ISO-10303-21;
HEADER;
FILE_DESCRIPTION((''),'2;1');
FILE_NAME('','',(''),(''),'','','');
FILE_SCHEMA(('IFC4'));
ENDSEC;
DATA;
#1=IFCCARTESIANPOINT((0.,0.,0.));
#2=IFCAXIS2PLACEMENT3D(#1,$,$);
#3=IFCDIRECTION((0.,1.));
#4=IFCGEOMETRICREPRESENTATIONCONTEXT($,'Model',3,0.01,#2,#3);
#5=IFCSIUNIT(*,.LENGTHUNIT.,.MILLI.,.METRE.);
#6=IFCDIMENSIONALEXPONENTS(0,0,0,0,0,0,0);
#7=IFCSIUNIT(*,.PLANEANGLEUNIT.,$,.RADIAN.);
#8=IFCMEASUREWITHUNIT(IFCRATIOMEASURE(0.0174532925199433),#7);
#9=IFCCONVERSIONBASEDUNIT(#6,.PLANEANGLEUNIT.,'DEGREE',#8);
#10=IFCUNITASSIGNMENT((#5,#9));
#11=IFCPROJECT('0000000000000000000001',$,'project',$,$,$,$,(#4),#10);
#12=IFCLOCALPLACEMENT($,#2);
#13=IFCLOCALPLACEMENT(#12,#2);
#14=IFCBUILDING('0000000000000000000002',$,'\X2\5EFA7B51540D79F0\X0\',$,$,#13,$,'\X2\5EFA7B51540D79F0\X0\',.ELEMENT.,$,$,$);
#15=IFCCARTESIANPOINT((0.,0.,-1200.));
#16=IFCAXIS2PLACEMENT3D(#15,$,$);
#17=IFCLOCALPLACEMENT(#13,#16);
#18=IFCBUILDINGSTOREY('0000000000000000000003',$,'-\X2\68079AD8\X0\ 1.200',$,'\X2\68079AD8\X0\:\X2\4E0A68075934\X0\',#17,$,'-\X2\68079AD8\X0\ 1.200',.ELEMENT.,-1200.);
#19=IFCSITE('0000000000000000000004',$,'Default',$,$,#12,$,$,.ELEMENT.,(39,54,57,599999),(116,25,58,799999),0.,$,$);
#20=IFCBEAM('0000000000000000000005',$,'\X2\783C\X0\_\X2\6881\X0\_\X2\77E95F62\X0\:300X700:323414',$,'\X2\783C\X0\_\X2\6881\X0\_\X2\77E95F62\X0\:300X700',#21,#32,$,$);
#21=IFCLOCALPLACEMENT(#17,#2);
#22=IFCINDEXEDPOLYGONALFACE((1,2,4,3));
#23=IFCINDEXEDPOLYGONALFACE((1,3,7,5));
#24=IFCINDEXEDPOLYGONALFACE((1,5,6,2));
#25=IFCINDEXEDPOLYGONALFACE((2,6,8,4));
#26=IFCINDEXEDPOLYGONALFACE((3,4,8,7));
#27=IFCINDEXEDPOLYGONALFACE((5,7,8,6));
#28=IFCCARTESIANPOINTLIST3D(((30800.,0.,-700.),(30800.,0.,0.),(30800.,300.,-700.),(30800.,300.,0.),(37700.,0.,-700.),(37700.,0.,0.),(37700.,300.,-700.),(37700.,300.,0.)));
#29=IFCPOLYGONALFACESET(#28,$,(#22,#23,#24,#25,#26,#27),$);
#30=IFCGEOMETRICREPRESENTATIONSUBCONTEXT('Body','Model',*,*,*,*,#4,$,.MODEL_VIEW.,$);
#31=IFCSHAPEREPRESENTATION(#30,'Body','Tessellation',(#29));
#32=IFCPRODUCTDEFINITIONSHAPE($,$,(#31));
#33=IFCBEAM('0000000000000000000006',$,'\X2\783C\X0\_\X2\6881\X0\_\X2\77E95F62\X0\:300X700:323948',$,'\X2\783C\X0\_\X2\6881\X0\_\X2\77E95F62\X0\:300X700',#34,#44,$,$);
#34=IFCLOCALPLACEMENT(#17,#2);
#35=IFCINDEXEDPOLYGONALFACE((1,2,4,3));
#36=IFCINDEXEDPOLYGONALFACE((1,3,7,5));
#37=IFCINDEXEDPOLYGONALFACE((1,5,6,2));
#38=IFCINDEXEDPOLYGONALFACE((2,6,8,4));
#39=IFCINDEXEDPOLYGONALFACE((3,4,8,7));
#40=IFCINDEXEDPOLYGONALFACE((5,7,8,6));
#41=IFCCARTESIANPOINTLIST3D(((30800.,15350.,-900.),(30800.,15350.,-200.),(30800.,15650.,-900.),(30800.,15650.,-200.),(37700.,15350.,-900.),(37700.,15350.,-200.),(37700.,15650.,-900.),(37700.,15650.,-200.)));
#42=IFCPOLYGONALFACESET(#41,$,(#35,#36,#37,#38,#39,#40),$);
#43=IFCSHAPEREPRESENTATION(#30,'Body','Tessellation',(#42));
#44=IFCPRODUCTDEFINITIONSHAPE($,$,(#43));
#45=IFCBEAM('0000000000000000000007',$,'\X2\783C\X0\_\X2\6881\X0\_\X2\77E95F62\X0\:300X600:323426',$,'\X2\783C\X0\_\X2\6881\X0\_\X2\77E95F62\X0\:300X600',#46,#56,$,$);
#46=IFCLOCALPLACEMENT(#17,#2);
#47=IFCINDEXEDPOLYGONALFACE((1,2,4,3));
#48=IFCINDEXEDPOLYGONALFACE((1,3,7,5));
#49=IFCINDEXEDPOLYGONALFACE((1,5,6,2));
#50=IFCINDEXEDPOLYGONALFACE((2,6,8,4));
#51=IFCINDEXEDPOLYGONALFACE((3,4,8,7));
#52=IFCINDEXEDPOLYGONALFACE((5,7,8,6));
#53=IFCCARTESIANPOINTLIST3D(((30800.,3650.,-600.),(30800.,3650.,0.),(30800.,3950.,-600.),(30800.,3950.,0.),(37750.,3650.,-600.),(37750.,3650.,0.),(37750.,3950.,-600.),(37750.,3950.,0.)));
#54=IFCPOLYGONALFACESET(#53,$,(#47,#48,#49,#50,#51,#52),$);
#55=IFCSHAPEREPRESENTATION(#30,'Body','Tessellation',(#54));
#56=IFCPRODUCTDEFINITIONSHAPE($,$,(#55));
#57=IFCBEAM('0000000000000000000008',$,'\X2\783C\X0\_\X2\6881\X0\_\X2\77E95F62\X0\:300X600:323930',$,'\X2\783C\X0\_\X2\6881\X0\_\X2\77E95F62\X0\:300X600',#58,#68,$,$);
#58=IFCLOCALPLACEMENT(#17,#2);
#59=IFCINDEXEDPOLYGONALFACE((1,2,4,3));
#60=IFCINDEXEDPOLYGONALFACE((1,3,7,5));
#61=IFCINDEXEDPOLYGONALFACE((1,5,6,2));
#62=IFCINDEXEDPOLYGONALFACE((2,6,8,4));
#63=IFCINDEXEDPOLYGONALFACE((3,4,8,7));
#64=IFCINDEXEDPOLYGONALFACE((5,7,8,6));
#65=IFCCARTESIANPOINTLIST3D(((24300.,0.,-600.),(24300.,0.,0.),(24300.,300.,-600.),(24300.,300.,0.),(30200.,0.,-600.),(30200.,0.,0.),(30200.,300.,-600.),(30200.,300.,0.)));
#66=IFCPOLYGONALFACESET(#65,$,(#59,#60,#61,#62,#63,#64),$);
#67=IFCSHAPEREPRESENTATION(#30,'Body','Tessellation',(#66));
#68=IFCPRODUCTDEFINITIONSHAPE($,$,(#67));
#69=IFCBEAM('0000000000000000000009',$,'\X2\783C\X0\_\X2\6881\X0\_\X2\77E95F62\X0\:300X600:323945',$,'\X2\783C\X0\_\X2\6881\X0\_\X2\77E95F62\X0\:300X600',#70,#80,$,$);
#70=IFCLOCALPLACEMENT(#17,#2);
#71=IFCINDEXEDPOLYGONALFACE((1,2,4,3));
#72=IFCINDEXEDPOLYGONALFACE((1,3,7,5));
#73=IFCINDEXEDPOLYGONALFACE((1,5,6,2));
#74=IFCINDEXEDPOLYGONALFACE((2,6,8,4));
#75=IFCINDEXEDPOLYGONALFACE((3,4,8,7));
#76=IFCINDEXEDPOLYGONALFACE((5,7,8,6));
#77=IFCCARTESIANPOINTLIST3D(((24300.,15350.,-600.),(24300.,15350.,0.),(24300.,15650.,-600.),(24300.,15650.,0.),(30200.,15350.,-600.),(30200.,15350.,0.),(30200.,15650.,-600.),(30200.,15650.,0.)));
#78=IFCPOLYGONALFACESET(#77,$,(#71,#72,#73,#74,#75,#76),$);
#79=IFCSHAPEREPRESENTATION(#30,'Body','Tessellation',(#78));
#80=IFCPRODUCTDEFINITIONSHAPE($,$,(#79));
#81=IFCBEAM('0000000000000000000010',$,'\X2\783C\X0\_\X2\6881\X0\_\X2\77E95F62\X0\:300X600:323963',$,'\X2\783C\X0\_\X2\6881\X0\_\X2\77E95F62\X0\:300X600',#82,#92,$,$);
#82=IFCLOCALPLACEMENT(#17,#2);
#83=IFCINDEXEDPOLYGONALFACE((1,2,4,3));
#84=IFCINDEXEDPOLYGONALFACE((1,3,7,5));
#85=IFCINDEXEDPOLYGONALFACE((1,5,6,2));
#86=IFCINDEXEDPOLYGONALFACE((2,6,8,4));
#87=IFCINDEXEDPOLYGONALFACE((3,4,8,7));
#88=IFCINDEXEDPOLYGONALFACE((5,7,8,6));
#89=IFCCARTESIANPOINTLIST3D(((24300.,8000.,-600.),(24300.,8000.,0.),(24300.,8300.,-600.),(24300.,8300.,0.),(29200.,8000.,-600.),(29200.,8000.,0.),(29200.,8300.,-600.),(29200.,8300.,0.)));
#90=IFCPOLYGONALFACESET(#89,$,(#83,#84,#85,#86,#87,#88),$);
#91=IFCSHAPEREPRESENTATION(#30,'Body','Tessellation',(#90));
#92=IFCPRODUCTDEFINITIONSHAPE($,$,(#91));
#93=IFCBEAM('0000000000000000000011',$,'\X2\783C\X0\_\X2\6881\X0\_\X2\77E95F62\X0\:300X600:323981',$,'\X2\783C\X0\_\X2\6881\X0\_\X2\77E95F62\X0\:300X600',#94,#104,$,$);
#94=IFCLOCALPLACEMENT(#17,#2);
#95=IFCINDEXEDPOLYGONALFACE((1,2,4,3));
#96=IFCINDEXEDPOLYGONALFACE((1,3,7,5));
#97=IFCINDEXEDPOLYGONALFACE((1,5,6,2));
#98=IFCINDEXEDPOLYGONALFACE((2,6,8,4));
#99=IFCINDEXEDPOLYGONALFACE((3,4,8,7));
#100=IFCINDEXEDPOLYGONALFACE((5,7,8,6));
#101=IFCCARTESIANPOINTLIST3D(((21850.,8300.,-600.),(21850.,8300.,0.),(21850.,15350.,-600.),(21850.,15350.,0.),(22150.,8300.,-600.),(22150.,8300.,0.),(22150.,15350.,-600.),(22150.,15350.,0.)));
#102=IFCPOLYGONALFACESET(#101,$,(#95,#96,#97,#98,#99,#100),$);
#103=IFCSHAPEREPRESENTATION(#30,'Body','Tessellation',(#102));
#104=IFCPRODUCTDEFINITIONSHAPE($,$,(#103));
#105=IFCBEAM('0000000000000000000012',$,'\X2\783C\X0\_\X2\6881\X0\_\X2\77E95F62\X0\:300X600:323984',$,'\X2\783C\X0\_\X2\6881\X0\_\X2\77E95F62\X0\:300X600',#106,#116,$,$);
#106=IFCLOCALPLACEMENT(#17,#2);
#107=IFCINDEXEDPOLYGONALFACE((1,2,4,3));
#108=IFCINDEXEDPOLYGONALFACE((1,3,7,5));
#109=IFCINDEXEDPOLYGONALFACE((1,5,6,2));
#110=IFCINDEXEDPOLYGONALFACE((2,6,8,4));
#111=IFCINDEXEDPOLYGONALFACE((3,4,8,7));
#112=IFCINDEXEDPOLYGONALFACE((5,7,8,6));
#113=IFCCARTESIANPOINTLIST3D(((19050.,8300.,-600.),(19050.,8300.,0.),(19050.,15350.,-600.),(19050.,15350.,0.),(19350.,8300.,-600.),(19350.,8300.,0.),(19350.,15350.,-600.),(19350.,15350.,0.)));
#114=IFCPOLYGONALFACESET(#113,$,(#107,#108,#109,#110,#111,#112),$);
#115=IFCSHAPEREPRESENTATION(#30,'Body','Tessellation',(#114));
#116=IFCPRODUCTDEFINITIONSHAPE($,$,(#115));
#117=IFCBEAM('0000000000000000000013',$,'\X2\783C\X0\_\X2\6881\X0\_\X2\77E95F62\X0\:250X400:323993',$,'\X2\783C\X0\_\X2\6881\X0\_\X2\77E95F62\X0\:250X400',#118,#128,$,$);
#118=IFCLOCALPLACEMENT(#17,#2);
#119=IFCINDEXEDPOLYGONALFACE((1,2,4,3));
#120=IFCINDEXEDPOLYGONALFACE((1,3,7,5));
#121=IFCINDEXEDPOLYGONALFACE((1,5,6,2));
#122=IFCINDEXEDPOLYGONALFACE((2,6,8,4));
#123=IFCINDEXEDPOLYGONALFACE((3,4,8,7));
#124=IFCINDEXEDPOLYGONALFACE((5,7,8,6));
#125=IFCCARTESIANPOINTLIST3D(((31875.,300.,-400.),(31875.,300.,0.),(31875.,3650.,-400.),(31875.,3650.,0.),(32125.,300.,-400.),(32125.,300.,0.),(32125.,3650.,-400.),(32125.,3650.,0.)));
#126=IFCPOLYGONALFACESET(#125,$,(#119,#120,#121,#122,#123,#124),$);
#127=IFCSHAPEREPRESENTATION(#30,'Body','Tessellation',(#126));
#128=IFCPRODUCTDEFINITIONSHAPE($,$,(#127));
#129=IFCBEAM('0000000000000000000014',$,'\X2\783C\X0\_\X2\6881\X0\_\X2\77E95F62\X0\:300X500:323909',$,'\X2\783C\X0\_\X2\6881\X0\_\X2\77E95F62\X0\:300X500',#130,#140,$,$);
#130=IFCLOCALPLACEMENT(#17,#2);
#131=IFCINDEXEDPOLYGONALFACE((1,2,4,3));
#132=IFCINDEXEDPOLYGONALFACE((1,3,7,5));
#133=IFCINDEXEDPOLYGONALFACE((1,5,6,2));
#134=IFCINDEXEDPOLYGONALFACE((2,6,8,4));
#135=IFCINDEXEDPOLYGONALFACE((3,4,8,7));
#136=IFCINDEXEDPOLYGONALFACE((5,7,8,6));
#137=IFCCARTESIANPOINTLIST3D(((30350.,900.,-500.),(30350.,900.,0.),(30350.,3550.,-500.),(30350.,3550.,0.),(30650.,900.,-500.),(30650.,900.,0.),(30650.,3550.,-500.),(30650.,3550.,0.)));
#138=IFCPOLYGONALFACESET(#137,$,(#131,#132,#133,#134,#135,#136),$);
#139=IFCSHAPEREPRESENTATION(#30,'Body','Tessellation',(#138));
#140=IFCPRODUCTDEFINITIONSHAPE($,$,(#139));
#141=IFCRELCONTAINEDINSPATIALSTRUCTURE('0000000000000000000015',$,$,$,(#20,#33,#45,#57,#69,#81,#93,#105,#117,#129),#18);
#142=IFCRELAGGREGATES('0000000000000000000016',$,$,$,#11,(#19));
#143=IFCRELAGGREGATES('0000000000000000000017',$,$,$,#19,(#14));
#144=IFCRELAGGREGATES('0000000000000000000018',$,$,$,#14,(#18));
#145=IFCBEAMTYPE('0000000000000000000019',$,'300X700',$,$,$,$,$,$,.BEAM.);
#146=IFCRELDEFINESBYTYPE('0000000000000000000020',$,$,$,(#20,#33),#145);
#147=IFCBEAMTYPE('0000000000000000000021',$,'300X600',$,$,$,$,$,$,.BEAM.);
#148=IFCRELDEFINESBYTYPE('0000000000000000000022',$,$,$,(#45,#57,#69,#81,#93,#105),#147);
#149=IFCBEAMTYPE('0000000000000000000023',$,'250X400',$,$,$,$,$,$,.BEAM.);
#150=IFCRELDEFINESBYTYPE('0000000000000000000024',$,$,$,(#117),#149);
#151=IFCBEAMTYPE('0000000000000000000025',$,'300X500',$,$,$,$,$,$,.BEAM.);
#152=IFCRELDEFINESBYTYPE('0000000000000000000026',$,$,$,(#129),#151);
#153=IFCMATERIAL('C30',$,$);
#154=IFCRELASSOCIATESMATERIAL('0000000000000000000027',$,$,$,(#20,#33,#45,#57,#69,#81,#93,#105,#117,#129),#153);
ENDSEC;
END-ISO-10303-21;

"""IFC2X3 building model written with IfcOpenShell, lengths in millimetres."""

from ifc_helpers import new_model, entity, si_unit, converted_unit, direction, frame, frame_2d, origin, place, context, subcontext, project, spatial, rectangle, extrude, material, type_object, element, save


model = new_model("IFC2X3")

# Units and contexts
model_context = context("Model", 3, precision=0.01, world=origin(), true_north=direction((0.0, 1.0)))
body_context = subcontext(model_context, "Body", "Model", "MODEL_VIEW")
ifc_project = project(units=[si_unit("LENGTHUNIT", "METRE", prefix="MILLI"), converted_unit("PLANEANGLEUNIT", "DEGREE", entity("IfcRatioMeasure", 0.0174532925199433), si_unit("PLANEANGLEUNIT", "RADIAN"), dimensions=[0, 0, 0, 0, 0, 0, 0])], contexts=[model_context])

# Site, building, storey
site_placement = place(None, origin())
site = spatial("IfcSite", under=ifc_project, at=site_placement, Name="Default", CompositionType="ELEMENT", RefLatitude=(39, 54, 57, 599999), RefLongitude=(116, 25, 58, 799999), RefElevation=0.0)
building_placement = place(site_placement, origin())
building = spatial("IfcBuilding", under=site, at=building_placement, Name="建筑名称", LongName="建筑名称", CompositionType="ELEMENT")
storey_placement = place(building_placement, frame((0.0, 0.0, -1200.0)))
storey = spatial("IfcBuildingStorey", under=building, at=storey_placement, Name="-标高 1.200", ObjectType="标高:上标头", LongName="-标高 1.200", CompositionType="ELEMENT", Elevation=-1200.0)

# Beams
ifc_material_1 = material(Name="C30")
beam_type_1 = type_object("IfcBeamType", Name="300X700", PredefinedType="BEAM")
beam_1_placement = place(storey_placement, frame((30500.0, 0.0, 0.0)))
element("IfcBeam", 1, at=beam_1_placement, inside=storey, type_object=beam_type_1, material=ifc_material_1, Name="砼_梁_矩形:300X700:323414", ObjectType="砼_梁_矩形:300X700", context=body_context, shape_type="SweptSolid", body=[
    extrude(rectangle(XDim=700.0, YDim=300.0, at=frame_2d((0.0, 0.0), x_axis=(1.0, 0.0))), frame((300.0, 150.0, -350.0), z_axis=(1.0, 0.0, 0.0), x_axis=(0.0, 0.0, -1.0)), (0.0, 0.0, 1.0), 6900.0),
])
beam_2_placement = place(storey_placement, frame((30500.0, 15650.0, 0.0)))
element("IfcBeam", 2, at=beam_2_placement, inside=storey, type_object=beam_type_1, material=ifc_material_1, Name="砼_梁_矩形:300X700:323948", ObjectType="砼_梁_矩形:300X700", context=body_context, shape_type="SweptSolid", body=[
    extrude(rectangle(XDim=700.0, YDim=300.0, at=frame_2d((0.0, 0.0), x_axis=(1.0, 0.0))), frame((300.0, -150.0, -550.0), z_axis=(1.0, 0.0, 0.0), x_axis=(0.0, 0.0, -1.0)), (0.0, 0.0, 1.0), 6900.0),
])
beam_type_2 = type_object("IfcBeamType", Name="300X600", PredefinedType="BEAM")
beam_3_placement = place(storey_placement, frame((30500.0, 3800.0, 0.0)))
element("IfcBeam", 3, at=beam_3_placement, inside=storey, type_object=beam_type_2, material=ifc_material_1, Name="砼_梁_矩形:300X600:323426", ObjectType="砼_梁_矩形:300X600", context=body_context, shape_type="SweptSolid", body=[
    extrude(rectangle(XDim=600.0, YDim=300.0, at=frame_2d((0.0, 0.0), x_axis=(1.0, 0.0))), frame((300.0, 0.0, -300.0), z_axis=(1.0, 0.0, 0.0), x_axis=(0.0, 0.0, -1.0)), (0.0, 0.0, 1.0), 6950.0),
])
beam_4_placement = place(storey_placement, frame((24000.0, 0.0, 0.0)))
element("IfcBeam", 4, at=beam_4_placement, inside=storey, type_object=beam_type_2, material=ifc_material_1, Name="砼_梁_矩形:300X600:323930", ObjectType="砼_梁_矩形:300X600", context=body_context, shape_type="SweptSolid", body=[
    extrude(rectangle(XDim=600.0, YDim=300.0, at=frame_2d((0.0, 0.0), x_axis=(1.0, 0.0))), frame((300.0, 150.0, -300.0), z_axis=(1.0, 0.0, 0.0), x_axis=(0.0, 0.0, -1.0)), (0.0, 0.0, 1.0), 5900.0),
])
beam_5_placement = place(storey_placement, frame((24000.0, 15650.0, 0.0)))
element("IfcBeam", 5, at=beam_5_placement, inside=storey, type_object=beam_type_2, material=ifc_material_1, Name="砼_梁_矩形:300X600:323945", ObjectType="砼_梁_矩形:300X600", context=body_context, shape_type="SweptSolid", body=[
    extrude(rectangle(XDim=600.0, YDim=300.0, at=frame_2d((0.0, 0.0), x_axis=(1.0, 0.0))), frame((300.0, -150.0, -300.0), z_axis=(1.0, 0.0, 0.0), x_axis=(0.0, 0.0, -1.0)), (0.0, 0.0, 1.0), 5900.0),
])
beam_6_placement = place(storey_placement, frame((24000.0, 8150.0, 0.0)))
element("IfcBeam", 6, at=beam_6_placement, inside=storey, type_object=beam_type_2, material=ifc_material_1, Name="砼_梁_矩形:300X600:323963", ObjectType="砼_梁_矩形:300X600", context=body_context, shape_type="SweptSolid", body=[
    extrude(rectangle(XDim=600.0, YDim=300.0, at=frame_2d((0.0, 0.0), x_axis=(1.0, 0.0))), frame((300.0, 0.0, -300.0), z_axis=(1.0, 0.0, 0.0), x_axis=(0.0, 0.0, -1.0)), (0.0, 0.0, 1.0), 4900.0),
])
beam_7_placement = place(storey_placement, frame((22000.0, 8150.0, 0.0), z_axis=(0.0, 0.0, 1.0), x_axis=(0.0, 1.0, 0.0)))
element("IfcBeam", 7, at=beam_7_placement, inside=storey, type_object=beam_type_2, material=ifc_material_1, Name="砼_梁_矩形:300X600:323981", ObjectType="砼_梁_矩形:300X600", context=body_context, shape_type="SweptSolid", body=[
    extrude(rectangle(XDim=600.0, YDim=300.0, at=frame_2d((0.0, 0.0), x_axis=(1.0, 0.0))), frame((150.0, 0.0, -300.0), z_axis=(1.0, 0.0, 0.0), x_axis=(0.0, 0.0, -1.0)), (0.0, 0.0, 1.0), 7050.0),
])
beam_8_placement = place(storey_placement, frame((19200.0, 8150.0, 0.0), z_axis=(0.0, 0.0, 1.0), x_axis=(0.0, 1.0, 0.0)))
element("IfcBeam", 8, at=beam_8_placement, inside=storey, type_object=beam_type_2, material=ifc_material_1, Name="砼_梁_矩形:300X600:323984", ObjectType="砼_梁_矩形:300X600", context=body_context, shape_type="SweptSolid", body=[
    extrude(rectangle(XDim=600.0, YDim=300.0, at=frame_2d((0.0, 0.0), x_axis=(1.0, 0.0))), frame((150.0, 0.0, -300.0), z_axis=(1.0, 0.0, 0.0), x_axis=(0.0, 0.0, -1.0)), (0.0, 0.0, 1.0), 7050.0),
])
beam_type_3 = type_object("IfcBeamType", Name="250X400", PredefinedType="BEAM")
beam_9_placement = place(storey_placement, frame((32000.0, 0.0, 0.0), z_axis=(0.0, 0.0, 1.0), x_axis=(0.0, 1.0, 0.0)))
element("IfcBeam", 9, at=beam_9_placement, inside=storey, type_object=beam_type_3, material=ifc_material_1, Name="砼_梁_矩形:250X400:323993", ObjectType="砼_梁_矩形:250X400", context=body_context, shape_type="SweptSolid", body=[
    extrude(rectangle(XDim=400.0, YDim=250.0, at=frame_2d((0.0, 0.0), x_axis=(1.0, 0.0))), frame((300.0, 0.0, -200.0), z_axis=(1.0, 0.0, 0.0), x_axis=(0.0, 0.0, -1.0)), (0.0, 0.0, 1.0), 3350.0),
])
beam_type_4 = type_object("IfcBeamType", Name="300X500", PredefinedType="BEAM")
beam_10_placement = place(storey_placement, frame((30500.0, 0.0, 0.0), z_axis=(0.0, 0.0, 1.0), x_axis=(0.0, 1.0, 0.0)))
element("IfcBeam", 10, at=beam_10_placement, inside=storey, type_object=beam_type_4, material=ifc_material_1, Name="砼_梁_矩形:300X500:323909", ObjectType="砼_梁_矩形:300X500", context=body_context, shape_type="SweptSolid", body=[
    extrude(rectangle(XDim=500.0, YDim=300.0, at=frame_2d((0.0, 0.0), x_axis=(1.0, 0.0))), frame((900.0, 0.0, -250.0), z_axis=(1.0, 0.0, 0.0), x_axis=(0.0, 0.0, -1.0)), (0.0, 0.0, 1.0), 2650.0),
])

save(model, "model.ifc")
